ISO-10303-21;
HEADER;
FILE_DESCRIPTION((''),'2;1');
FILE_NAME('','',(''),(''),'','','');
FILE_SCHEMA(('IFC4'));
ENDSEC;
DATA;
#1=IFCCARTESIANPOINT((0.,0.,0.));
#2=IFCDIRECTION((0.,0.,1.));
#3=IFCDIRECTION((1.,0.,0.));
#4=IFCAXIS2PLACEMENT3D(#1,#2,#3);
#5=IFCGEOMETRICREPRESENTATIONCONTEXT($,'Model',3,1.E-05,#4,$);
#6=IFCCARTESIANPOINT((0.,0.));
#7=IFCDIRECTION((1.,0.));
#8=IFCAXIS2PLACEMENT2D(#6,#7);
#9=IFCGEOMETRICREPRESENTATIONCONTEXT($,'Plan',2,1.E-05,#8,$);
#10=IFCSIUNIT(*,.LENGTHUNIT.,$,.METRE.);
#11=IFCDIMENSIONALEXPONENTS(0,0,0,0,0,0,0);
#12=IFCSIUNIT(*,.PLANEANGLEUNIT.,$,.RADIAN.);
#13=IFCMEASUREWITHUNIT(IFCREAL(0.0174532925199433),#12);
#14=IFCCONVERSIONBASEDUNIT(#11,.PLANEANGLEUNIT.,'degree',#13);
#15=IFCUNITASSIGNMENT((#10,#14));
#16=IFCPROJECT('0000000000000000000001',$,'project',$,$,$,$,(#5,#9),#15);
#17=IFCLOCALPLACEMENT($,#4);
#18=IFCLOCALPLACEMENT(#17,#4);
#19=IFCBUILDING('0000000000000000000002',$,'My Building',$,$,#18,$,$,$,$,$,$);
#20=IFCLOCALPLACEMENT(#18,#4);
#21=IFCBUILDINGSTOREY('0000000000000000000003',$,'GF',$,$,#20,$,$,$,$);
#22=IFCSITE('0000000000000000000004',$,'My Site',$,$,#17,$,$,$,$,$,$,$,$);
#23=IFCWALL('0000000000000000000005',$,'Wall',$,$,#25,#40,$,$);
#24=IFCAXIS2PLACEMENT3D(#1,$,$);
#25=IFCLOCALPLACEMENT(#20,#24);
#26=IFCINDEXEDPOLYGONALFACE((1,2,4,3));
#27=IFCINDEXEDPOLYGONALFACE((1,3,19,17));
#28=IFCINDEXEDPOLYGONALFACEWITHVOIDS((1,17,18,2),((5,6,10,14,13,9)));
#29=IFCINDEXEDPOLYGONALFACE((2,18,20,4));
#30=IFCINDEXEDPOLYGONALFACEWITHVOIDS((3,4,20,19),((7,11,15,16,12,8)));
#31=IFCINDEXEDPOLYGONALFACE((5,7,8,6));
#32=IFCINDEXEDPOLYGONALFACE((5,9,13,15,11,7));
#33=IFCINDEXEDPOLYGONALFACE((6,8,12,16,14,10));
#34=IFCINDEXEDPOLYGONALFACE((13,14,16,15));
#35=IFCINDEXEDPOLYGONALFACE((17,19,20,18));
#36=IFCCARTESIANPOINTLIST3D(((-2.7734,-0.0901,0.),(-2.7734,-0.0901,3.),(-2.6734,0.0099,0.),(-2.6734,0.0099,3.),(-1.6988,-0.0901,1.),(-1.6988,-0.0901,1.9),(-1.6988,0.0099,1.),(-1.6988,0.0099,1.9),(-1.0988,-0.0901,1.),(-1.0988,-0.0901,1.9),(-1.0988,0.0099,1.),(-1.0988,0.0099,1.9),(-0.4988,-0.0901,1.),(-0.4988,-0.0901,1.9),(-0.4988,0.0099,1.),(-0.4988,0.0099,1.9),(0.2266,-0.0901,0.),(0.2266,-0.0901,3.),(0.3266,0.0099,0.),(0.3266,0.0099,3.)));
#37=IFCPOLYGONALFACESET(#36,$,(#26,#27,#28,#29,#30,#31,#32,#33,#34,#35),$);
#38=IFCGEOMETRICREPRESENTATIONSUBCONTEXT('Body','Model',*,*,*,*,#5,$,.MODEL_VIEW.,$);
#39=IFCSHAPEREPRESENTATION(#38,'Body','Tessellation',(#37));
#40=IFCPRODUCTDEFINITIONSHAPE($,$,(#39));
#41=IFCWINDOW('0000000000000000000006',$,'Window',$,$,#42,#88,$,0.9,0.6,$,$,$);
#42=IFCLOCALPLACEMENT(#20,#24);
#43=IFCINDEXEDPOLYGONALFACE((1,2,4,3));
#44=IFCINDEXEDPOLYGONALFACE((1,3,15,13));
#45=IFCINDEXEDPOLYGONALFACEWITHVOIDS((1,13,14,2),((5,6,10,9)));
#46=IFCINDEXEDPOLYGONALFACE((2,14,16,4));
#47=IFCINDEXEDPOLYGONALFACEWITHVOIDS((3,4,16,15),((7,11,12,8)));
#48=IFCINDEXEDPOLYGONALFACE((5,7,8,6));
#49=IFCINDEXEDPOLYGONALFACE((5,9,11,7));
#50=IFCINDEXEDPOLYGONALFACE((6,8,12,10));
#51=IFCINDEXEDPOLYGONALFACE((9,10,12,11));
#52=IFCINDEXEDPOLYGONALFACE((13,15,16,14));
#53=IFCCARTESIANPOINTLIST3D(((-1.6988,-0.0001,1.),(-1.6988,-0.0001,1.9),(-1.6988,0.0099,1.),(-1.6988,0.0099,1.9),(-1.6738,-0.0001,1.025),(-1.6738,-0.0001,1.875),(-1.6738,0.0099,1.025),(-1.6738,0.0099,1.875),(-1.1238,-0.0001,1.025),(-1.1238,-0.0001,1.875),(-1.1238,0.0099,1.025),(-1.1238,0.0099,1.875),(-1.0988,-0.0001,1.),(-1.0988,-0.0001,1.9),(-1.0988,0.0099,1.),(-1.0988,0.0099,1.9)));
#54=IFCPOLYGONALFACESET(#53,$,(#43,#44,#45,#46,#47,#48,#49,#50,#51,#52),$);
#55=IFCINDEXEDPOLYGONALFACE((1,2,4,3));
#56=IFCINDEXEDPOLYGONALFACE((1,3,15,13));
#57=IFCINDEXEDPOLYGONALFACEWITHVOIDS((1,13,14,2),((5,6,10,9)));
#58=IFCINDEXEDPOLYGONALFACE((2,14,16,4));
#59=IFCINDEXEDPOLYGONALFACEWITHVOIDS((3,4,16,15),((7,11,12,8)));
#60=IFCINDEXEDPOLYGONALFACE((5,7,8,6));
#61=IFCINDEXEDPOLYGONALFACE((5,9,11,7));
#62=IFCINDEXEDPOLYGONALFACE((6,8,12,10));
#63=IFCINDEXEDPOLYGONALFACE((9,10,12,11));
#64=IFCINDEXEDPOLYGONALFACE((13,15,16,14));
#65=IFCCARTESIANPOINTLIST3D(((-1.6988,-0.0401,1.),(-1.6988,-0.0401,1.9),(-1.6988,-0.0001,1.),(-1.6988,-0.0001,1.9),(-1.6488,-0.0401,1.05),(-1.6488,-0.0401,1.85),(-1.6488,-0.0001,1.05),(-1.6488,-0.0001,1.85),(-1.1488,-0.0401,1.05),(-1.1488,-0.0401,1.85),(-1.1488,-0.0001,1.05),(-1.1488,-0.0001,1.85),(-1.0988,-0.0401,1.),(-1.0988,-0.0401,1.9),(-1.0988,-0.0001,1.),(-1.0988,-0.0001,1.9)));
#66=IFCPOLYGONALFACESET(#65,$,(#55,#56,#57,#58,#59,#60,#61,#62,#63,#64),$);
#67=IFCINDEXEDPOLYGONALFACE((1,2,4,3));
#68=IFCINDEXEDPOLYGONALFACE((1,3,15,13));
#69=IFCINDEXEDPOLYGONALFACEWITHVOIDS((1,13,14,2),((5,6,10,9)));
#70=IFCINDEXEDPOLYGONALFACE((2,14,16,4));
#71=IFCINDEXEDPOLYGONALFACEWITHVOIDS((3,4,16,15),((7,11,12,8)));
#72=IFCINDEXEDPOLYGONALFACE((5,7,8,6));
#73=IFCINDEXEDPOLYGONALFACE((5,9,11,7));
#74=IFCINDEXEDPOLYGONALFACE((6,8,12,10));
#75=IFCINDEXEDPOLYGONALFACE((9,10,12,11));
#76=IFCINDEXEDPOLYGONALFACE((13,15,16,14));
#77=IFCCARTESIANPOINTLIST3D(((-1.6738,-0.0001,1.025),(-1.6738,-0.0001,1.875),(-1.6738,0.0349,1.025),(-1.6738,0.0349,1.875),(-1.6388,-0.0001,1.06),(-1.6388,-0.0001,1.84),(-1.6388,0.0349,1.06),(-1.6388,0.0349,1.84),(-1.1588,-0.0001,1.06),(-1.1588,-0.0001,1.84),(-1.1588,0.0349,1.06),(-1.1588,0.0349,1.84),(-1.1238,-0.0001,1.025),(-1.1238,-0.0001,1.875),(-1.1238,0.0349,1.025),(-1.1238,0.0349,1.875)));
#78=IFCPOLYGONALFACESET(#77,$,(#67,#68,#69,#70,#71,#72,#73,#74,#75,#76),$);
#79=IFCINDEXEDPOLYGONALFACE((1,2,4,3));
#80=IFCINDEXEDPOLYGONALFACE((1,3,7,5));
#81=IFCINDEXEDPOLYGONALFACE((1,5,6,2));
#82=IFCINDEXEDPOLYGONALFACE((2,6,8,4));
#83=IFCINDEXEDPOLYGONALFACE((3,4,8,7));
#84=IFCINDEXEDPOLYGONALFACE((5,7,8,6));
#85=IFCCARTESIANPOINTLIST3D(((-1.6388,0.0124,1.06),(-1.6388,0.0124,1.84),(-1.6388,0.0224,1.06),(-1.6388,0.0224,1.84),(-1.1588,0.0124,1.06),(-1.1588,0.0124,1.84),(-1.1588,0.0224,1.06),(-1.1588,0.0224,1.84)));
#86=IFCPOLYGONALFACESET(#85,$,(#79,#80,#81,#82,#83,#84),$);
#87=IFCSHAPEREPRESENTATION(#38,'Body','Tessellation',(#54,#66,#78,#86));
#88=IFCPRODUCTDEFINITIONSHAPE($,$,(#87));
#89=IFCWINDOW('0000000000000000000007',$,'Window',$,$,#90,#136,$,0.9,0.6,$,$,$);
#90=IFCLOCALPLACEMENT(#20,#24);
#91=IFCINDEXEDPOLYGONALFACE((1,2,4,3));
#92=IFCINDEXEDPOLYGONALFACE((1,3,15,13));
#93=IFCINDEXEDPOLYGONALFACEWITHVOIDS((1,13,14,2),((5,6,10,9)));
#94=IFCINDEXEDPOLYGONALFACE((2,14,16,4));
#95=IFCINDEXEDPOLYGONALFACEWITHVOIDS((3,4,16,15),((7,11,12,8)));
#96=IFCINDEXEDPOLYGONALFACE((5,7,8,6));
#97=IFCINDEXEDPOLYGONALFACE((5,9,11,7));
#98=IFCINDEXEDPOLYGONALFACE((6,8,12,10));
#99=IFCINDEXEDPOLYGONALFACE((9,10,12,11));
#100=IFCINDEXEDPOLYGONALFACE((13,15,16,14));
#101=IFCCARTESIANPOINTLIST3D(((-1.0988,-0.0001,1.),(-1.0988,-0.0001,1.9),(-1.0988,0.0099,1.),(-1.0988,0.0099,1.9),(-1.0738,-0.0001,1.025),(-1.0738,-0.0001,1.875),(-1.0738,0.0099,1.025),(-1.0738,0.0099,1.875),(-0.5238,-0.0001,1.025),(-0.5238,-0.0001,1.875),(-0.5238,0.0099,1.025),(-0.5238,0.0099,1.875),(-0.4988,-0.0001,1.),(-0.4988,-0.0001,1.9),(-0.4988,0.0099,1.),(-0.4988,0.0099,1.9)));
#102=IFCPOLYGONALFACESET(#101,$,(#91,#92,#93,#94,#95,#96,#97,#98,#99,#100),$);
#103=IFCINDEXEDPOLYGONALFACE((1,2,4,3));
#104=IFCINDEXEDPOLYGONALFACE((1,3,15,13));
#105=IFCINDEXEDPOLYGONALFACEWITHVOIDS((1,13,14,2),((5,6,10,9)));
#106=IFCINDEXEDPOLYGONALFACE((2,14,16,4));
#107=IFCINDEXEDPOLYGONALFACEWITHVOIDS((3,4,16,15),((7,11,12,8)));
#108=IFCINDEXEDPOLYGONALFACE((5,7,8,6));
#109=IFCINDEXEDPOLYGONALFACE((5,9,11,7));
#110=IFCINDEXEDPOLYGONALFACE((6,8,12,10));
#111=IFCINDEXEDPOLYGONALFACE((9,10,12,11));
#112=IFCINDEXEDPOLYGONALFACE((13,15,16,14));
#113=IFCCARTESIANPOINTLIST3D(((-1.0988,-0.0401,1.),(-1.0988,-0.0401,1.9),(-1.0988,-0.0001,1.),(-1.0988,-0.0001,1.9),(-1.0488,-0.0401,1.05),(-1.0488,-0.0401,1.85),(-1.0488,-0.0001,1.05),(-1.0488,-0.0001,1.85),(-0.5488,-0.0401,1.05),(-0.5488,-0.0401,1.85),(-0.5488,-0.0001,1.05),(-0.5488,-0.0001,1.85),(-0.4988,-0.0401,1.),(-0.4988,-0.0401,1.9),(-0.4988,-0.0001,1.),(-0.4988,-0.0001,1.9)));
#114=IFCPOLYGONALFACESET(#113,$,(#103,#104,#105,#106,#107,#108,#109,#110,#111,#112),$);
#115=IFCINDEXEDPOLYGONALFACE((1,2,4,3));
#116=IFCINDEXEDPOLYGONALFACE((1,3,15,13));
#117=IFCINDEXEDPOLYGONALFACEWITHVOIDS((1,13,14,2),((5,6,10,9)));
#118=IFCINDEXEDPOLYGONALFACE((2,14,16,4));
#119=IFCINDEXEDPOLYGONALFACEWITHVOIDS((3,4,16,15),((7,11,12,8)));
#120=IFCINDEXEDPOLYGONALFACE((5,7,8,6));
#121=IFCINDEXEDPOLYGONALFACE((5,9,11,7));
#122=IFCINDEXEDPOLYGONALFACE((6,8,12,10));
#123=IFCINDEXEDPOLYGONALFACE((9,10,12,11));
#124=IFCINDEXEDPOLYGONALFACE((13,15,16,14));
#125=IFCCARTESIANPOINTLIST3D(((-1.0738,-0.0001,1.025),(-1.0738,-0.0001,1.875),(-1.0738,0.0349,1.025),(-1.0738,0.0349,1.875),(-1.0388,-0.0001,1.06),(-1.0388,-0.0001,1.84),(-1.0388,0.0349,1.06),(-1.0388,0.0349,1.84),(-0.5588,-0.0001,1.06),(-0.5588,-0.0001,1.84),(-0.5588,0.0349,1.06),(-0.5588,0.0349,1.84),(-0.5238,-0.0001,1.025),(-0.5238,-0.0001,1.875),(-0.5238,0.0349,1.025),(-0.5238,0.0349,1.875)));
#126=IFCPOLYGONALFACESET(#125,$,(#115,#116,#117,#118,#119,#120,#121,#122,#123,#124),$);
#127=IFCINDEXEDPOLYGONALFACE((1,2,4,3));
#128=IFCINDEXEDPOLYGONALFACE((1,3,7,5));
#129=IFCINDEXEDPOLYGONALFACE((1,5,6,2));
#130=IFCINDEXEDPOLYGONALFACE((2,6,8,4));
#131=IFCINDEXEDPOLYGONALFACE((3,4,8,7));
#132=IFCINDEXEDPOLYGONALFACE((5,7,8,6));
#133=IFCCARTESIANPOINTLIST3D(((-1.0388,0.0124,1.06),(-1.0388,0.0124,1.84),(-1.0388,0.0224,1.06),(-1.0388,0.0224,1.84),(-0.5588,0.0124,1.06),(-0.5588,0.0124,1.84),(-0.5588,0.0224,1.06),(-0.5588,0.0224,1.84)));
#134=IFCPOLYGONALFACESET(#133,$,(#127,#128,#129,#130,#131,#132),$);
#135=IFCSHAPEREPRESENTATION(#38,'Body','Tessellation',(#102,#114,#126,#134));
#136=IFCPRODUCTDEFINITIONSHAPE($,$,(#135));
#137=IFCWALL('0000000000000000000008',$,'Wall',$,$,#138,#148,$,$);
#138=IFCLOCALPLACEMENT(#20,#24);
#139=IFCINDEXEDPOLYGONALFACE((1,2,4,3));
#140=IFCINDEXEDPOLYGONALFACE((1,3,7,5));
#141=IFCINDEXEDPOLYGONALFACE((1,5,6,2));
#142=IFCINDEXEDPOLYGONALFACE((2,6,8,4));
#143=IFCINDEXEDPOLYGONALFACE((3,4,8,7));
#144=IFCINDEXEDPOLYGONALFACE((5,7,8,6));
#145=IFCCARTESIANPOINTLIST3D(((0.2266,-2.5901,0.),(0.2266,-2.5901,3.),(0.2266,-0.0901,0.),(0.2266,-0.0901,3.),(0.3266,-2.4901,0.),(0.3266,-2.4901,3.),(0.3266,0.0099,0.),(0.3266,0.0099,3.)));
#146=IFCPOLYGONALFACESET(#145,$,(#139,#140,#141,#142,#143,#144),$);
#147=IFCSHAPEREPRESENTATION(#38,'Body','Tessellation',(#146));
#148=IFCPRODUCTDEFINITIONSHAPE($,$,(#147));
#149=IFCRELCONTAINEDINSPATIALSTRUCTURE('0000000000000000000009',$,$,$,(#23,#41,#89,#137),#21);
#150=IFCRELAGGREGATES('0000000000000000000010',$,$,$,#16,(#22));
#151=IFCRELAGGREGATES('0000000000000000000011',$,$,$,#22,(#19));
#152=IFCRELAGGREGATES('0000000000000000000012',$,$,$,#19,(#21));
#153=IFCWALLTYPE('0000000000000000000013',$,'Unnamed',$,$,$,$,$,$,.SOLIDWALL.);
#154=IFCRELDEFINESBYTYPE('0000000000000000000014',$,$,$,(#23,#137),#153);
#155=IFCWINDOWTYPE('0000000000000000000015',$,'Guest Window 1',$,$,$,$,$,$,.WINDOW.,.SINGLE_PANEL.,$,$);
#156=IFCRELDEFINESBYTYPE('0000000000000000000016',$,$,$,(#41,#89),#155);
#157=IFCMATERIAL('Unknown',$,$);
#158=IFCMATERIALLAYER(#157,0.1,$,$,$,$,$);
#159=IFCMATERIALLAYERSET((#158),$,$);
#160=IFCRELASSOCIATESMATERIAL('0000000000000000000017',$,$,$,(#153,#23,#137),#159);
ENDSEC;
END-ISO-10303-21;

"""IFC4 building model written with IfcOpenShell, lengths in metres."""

from ifc_helpers import new_model, entity, si_unit, converted_unit, frame, origin_with_axes, origin_2d_with_axis, place, context, subcontext, project, spatial, line, indexed_curve, outline, extrude, shape, source, transform, mapped, material, layer, layer_set, layer_usage, type_object, type_shapes, element, fill, save


model = new_model("IFC4")

# Units and contexts
model_context = context("Model", 3, precision=1e-05, world=origin_with_axes())
plan_context = context("Plan", 2, precision=1e-05, world=origin_2d_with_axis())
body_context_1 = subcontext(model_context, "Body", "Model", "MODEL_VIEW")
body_context_2 = subcontext(plan_context, "Body", "Plan", "PLAN_VIEW")
ifc_project = project(units=[si_unit("LENGTHUNIT", "METRE"), converted_unit("PLANEANGLEUNIT", "degree", entity("IfcReal", 0.0174532925199433), si_unit("PLANEANGLEUNIT", "RADIAN"), dimensions=[0, 0, 0, 0, 0, 0, 0])], contexts=[model_context, plan_context])

# Site, building, storey
site_placement = place(None, origin_with_axes())
site = spatial("IfcSite", under=ifc_project, at=site_placement, Name="My Site")
building_placement = place(site_placement, origin_with_axes())
building = spatial("IfcBuilding", under=site, at=building_placement, Name="My Building")
storey_placement = place(building_placement, origin_with_axes())
storey = spatial("IfcBuildingStorey", under=building, at=storey_placement, Name="GF")

# Shared definitions
ifc_material = material(Name="Unknown")

# Shared definitions
ifc_layer_1 = layer(ifc_material, 0.1)
ifc_layer_set_1 = layer_set([ifc_layer_1])
wall_type = type_object("IfcWallType", Name="Unnamed", PredefinedType="SOLIDWALL", material=ifc_layer_set_1)

# Wall, openings, windows
ifc_layer_usage_1 = layer_usage(ifc_layer_set_1, "AXIS2", "POSITIVE", 0.0)
wall_1_placement = place(storey_placement, frame((-2.7734, -0.0901, 0.0), z_axis=(0.0, 0.0, 1.0), x_axis=(1.0, 0.0, 0.0)))
wall_1 = element("IfcWall", 1, at=wall_1_placement, inside=storey, type_object=wall_type, material=ifc_layer_usage_1, Name="Wall", context=body_context_1, shape_type="SweptSolid", body=[
    extrude(outline(indexed_curve([(0.0, 0.0), (0.1, 0.1), (3.1, 0.1), (3.0, 0.0)], segments=[line(1, 2, 3, 4, 1)])), origin_with_axes(), (0.0, 0.0, 1.0), 3.0),
])
shared_shape_1 = source(origin_with_axes(), body_context_1, "Body", "SweptSolid", [
    extrude(outline(indexed_curve([(0.0, 0.0), (0.6, 0.0), (0.6, 0.9), (0.0, 0.9)], segments=[line(1, 2, 3, 4, 1)])), frame((0.0, -0.6, 0.0), z_axis=(0.0, -1.0, 0.0), x_axis=(1.0, 0.0, 0.0)), (0.0, 0.0, -1.0), 1.2),
])
opening_1_placement = place(wall_1_placement, frame((1.0746, 0.0, 1.0), z_axis=(0.0, 0.0, 1.0), x_axis=(1.0, 0.0, 0.0)))
opening_1 = element("IfcOpeningElement", 2, at=opening_1_placement, cuts=wall_1, PredefinedType="OPENING", context=body_context_1, shape_type="MappedRepresentation", body=[
    mapped(shared_shape_1, transform((0.0, 0.0, 0.0), x_axis=(1.0, 0.0, 0.0), y_axis=(0.0, 1.0, 0.0), z_axis=(0.0, 0.0, 1.0), scale=1.0)),
])
opening_2_placement = place(wall_1_placement, frame((1.6746, 0.0, 1.0), z_axis=(0.0, 0.0, 1.0), x_axis=(1.0, 0.0, 0.0)))
opening_2 = element("IfcOpeningElement", 3, at=opening_2_placement, cuts=wall_1, PredefinedType="OPENING", context=body_context_1, shape_type="MappedRepresentation", body=[
    mapped(shared_shape_1, transform((0.0, 0.0, 0.0), x_axis=(1.0, 0.0, 0.0), y_axis=(0.0, 1.0, 0.0), z_axis=(0.0, 0.0, 1.0), scale=1.0)),
])
window_type_1 = type_object("IfcWindowType", Name="Guest Window 1", PartitioningType="SINGLE_PANEL", PredefinedType="WINDOW")
shared_shape_2 = source(origin_with_axes(), body_context_1, "Body", "SweptSolid", [
    extrude(outline(indexed_curve([(0.0, 0.0), (0.6, 0.0), (0.6, 0.9), (0.0, 0.9)], segments=[line(1, 2, 3, 4, 1)]), holes=[indexed_curve([(0.025, 0.025), (0.575, 0.025), (0.575, 0.875), (0.025, 0.875)], segments=[line(1, 2, 3, 4, 1)])]), frame((0.0, 0.09, 0.0), z_axis=(0.0, -1.0, 0.0), x_axis=(1.0, 0.0, 0.0)), (0.0, 0.0, -1.0), 0.01),
    extrude(outline(indexed_curve([(0.0, 0.0), (0.6, 0.0), (0.6, 0.9), (0.0, 0.9)], segments=[line(1, 2, 3, 4, 1)]), holes=[indexed_curve([(0.05, 0.05), (0.55, 0.05), (0.55, 0.85), (0.05, 0.85)], segments=[line(1, 2, 3, 4, 1)])]), frame((0.0, 0.05, 0.0), z_axis=(0.0, -1.0, 0.0), x_axis=(1.0, 0.0, 0.0)), (0.0, 0.0, -1.0), 0.04),
    extrude(outline(indexed_curve([(0.0, 0.0), (0.55, 0.0), (0.55, 0.85), (0.0, 0.85)], segments=[line(1, 2, 3, 4, 1)]), holes=[indexed_curve([(0.035, 0.035), (0.515, 0.035), (0.515, 0.815), (0.035, 0.815)], segments=[line(1, 2, 3, 4, 1)])]), frame((0.025, 0.09, 0.025), z_axis=(0.0, -1.0, 0.0), x_axis=(1.0, 0.0, 0.0)), (0.0, 0.0, -1.0), 0.035),
    extrude(outline(indexed_curve([(0.035, 0.035), (0.515, 0.035), (0.515, 0.815), (0.035, 0.815)], segments=[line(1, 2, 3, 4, 1)])), frame((0.025, 0.1025, 0.025), z_axis=(0.0, -1.0, 0.0), x_axis=(1.0, 0.0, 0.0)), (0.0, 0.0, -1.0), 0.01),
])
shared_shape_3 = source(origin_with_axes(), body_context_2, "Body", "Curve2D", [
    entity("IfcIndexedPolyCurve", entity("IfcCartesianPointList2D", [[0.05, 0.05], [0.55, 0.05]])),
    entity("IfcIndexedPolyCurve", entity("IfcCartesianPointList2D", [[0.0, 0.1], [0.025, 0.1], [0.025, 0.09], [0.05, 0.09], [0.05, 0.05], [0.0, 0.05]]), [entity("IfcLineIndex", [1, 2, 3, 4, 5, 6, 1])]),
    entity("IfcIndexedPolyCurve", entity("IfcCartesianPointList2D", [[0.6, 0.1], [0.575, 0.1], [0.575, 0.09], [0.55, 0.09], [0.55, 0.05], [0.6, 0.05]]), [entity("IfcLineIndex", [1, 2, 3, 4, 5, 6, 1])]),
    entity("IfcIndexedPolyCurve", entity("IfcCartesianPointList2D", [[0.025, 0.09], [0.06, 0.09], [0.06, 0.125], [0.025, 0.125]]), [entity("IfcLineIndex", [1, 2, 3, 4, 1])]),
    entity("IfcIndexedPolyCurve", entity("IfcCartesianPointList2D", [[0.575, 0.09], [0.54, 0.09], [0.54, 0.125], [0.575, 0.125]]), [entity("IfcLineIndex", [1, 2, 3, 4, 1])]),
    entity("IfcIndexedPolyCurve", entity("IfcCartesianPointList2D", [[0.06, 0.09], [0.54, 0.09]])),
    entity("IfcIndexedPolyCurve", entity("IfcCartesianPointList2D", [[0.06, 0.125], [0.54, 0.125]])),
    entity("IfcIndexedPolyCurve", entity("IfcCartesianPointList2D", [[0.06, 0.1075], [0.54, 0.1075]])),
])
type_shapes(window_type_1, [shared_shape_2, shared_shape_3])
window_1_placement = place(opening_1_placement, origin_with_axes())
window_1 = element("IfcWindow", 4, at=window_1_placement, inside=storey, type_object=window_type_1, Name="Window", OverallHeight=0.9, OverallWidth=0.6, shapes=[
    shape(body_context_1, "Body", "MappedRepresentation", [mapped(shared_shape_2, transform((0.0, 0.0, 0.0), x_axis=(1.0, 0.0, 0.0), y_axis=(0.0, 1.0, 0.0), z_axis=(0.0, 0.0, 1.0), scale=1.0))]),
    shape(body_context_2, "Body", "MappedRepresentation", [mapped(shared_shape_3, transform((0.0, 0.0, 0.0), x_axis=(1.0, 0.0, 0.0), y_axis=(0.0, 1.0, 0.0), z_axis=(0.0, 0.0, 1.0), scale=1.0))]),
])
fill(opening_1, window_1)
window_2_placement = place(opening_2_placement, origin_with_axes())
window_2 = element("IfcWindow", 5, at=window_2_placement, inside=storey, type_object=window_type_1, Name="Window", OverallHeight=0.9, OverallWidth=0.6, shapes=[
    shape(body_context_1, "Body", "MappedRepresentation", [mapped(shared_shape_2, transform((0.0, 0.0, 0.0), x_axis=(1.0, 0.0, 0.0), y_axis=(0.0, 1.0, 0.0), z_axis=(0.0, 0.0, 1.0), scale=1.0))]),
    shape(body_context_2, "Body", "MappedRepresentation", [mapped(shared_shape_3, transform((0.0, 0.0, 0.0), x_axis=(1.0, 0.0, 0.0), y_axis=(0.0, 1.0, 0.0), z_axis=(0.0, 0.0, 1.0), scale=1.0))]),
])
fill(opening_2, window_2)

# Wall
ifc_layer_usage_2 = layer_usage(ifc_layer_set_1, "AXIS2", "POSITIVE", 0.0)
wall_2_placement = place(storey_placement, frame((0.2266, -0.0901, 0.0), z_axis=(0.0, 0.0, 1.0), x_axis=(0.0, -1.0, 0.0)))
element("IfcWall", 6, at=wall_2_placement, inside=storey, type_object=wall_type, material=ifc_layer_usage_2, Name="Wall", context=body_context_1, shape_type="SweptSolid", body=[
    extrude(outline(indexed_curve([(0.0, 0.0), (-0.1, 0.1), (2.4, 0.1), (2.5, 0.0)], segments=[line(1, 2, 3, 4, 1)])), origin_with_axes(), (0.0, 0.0, 1.0), 3.0),
])

save(model, "model.ifc")
